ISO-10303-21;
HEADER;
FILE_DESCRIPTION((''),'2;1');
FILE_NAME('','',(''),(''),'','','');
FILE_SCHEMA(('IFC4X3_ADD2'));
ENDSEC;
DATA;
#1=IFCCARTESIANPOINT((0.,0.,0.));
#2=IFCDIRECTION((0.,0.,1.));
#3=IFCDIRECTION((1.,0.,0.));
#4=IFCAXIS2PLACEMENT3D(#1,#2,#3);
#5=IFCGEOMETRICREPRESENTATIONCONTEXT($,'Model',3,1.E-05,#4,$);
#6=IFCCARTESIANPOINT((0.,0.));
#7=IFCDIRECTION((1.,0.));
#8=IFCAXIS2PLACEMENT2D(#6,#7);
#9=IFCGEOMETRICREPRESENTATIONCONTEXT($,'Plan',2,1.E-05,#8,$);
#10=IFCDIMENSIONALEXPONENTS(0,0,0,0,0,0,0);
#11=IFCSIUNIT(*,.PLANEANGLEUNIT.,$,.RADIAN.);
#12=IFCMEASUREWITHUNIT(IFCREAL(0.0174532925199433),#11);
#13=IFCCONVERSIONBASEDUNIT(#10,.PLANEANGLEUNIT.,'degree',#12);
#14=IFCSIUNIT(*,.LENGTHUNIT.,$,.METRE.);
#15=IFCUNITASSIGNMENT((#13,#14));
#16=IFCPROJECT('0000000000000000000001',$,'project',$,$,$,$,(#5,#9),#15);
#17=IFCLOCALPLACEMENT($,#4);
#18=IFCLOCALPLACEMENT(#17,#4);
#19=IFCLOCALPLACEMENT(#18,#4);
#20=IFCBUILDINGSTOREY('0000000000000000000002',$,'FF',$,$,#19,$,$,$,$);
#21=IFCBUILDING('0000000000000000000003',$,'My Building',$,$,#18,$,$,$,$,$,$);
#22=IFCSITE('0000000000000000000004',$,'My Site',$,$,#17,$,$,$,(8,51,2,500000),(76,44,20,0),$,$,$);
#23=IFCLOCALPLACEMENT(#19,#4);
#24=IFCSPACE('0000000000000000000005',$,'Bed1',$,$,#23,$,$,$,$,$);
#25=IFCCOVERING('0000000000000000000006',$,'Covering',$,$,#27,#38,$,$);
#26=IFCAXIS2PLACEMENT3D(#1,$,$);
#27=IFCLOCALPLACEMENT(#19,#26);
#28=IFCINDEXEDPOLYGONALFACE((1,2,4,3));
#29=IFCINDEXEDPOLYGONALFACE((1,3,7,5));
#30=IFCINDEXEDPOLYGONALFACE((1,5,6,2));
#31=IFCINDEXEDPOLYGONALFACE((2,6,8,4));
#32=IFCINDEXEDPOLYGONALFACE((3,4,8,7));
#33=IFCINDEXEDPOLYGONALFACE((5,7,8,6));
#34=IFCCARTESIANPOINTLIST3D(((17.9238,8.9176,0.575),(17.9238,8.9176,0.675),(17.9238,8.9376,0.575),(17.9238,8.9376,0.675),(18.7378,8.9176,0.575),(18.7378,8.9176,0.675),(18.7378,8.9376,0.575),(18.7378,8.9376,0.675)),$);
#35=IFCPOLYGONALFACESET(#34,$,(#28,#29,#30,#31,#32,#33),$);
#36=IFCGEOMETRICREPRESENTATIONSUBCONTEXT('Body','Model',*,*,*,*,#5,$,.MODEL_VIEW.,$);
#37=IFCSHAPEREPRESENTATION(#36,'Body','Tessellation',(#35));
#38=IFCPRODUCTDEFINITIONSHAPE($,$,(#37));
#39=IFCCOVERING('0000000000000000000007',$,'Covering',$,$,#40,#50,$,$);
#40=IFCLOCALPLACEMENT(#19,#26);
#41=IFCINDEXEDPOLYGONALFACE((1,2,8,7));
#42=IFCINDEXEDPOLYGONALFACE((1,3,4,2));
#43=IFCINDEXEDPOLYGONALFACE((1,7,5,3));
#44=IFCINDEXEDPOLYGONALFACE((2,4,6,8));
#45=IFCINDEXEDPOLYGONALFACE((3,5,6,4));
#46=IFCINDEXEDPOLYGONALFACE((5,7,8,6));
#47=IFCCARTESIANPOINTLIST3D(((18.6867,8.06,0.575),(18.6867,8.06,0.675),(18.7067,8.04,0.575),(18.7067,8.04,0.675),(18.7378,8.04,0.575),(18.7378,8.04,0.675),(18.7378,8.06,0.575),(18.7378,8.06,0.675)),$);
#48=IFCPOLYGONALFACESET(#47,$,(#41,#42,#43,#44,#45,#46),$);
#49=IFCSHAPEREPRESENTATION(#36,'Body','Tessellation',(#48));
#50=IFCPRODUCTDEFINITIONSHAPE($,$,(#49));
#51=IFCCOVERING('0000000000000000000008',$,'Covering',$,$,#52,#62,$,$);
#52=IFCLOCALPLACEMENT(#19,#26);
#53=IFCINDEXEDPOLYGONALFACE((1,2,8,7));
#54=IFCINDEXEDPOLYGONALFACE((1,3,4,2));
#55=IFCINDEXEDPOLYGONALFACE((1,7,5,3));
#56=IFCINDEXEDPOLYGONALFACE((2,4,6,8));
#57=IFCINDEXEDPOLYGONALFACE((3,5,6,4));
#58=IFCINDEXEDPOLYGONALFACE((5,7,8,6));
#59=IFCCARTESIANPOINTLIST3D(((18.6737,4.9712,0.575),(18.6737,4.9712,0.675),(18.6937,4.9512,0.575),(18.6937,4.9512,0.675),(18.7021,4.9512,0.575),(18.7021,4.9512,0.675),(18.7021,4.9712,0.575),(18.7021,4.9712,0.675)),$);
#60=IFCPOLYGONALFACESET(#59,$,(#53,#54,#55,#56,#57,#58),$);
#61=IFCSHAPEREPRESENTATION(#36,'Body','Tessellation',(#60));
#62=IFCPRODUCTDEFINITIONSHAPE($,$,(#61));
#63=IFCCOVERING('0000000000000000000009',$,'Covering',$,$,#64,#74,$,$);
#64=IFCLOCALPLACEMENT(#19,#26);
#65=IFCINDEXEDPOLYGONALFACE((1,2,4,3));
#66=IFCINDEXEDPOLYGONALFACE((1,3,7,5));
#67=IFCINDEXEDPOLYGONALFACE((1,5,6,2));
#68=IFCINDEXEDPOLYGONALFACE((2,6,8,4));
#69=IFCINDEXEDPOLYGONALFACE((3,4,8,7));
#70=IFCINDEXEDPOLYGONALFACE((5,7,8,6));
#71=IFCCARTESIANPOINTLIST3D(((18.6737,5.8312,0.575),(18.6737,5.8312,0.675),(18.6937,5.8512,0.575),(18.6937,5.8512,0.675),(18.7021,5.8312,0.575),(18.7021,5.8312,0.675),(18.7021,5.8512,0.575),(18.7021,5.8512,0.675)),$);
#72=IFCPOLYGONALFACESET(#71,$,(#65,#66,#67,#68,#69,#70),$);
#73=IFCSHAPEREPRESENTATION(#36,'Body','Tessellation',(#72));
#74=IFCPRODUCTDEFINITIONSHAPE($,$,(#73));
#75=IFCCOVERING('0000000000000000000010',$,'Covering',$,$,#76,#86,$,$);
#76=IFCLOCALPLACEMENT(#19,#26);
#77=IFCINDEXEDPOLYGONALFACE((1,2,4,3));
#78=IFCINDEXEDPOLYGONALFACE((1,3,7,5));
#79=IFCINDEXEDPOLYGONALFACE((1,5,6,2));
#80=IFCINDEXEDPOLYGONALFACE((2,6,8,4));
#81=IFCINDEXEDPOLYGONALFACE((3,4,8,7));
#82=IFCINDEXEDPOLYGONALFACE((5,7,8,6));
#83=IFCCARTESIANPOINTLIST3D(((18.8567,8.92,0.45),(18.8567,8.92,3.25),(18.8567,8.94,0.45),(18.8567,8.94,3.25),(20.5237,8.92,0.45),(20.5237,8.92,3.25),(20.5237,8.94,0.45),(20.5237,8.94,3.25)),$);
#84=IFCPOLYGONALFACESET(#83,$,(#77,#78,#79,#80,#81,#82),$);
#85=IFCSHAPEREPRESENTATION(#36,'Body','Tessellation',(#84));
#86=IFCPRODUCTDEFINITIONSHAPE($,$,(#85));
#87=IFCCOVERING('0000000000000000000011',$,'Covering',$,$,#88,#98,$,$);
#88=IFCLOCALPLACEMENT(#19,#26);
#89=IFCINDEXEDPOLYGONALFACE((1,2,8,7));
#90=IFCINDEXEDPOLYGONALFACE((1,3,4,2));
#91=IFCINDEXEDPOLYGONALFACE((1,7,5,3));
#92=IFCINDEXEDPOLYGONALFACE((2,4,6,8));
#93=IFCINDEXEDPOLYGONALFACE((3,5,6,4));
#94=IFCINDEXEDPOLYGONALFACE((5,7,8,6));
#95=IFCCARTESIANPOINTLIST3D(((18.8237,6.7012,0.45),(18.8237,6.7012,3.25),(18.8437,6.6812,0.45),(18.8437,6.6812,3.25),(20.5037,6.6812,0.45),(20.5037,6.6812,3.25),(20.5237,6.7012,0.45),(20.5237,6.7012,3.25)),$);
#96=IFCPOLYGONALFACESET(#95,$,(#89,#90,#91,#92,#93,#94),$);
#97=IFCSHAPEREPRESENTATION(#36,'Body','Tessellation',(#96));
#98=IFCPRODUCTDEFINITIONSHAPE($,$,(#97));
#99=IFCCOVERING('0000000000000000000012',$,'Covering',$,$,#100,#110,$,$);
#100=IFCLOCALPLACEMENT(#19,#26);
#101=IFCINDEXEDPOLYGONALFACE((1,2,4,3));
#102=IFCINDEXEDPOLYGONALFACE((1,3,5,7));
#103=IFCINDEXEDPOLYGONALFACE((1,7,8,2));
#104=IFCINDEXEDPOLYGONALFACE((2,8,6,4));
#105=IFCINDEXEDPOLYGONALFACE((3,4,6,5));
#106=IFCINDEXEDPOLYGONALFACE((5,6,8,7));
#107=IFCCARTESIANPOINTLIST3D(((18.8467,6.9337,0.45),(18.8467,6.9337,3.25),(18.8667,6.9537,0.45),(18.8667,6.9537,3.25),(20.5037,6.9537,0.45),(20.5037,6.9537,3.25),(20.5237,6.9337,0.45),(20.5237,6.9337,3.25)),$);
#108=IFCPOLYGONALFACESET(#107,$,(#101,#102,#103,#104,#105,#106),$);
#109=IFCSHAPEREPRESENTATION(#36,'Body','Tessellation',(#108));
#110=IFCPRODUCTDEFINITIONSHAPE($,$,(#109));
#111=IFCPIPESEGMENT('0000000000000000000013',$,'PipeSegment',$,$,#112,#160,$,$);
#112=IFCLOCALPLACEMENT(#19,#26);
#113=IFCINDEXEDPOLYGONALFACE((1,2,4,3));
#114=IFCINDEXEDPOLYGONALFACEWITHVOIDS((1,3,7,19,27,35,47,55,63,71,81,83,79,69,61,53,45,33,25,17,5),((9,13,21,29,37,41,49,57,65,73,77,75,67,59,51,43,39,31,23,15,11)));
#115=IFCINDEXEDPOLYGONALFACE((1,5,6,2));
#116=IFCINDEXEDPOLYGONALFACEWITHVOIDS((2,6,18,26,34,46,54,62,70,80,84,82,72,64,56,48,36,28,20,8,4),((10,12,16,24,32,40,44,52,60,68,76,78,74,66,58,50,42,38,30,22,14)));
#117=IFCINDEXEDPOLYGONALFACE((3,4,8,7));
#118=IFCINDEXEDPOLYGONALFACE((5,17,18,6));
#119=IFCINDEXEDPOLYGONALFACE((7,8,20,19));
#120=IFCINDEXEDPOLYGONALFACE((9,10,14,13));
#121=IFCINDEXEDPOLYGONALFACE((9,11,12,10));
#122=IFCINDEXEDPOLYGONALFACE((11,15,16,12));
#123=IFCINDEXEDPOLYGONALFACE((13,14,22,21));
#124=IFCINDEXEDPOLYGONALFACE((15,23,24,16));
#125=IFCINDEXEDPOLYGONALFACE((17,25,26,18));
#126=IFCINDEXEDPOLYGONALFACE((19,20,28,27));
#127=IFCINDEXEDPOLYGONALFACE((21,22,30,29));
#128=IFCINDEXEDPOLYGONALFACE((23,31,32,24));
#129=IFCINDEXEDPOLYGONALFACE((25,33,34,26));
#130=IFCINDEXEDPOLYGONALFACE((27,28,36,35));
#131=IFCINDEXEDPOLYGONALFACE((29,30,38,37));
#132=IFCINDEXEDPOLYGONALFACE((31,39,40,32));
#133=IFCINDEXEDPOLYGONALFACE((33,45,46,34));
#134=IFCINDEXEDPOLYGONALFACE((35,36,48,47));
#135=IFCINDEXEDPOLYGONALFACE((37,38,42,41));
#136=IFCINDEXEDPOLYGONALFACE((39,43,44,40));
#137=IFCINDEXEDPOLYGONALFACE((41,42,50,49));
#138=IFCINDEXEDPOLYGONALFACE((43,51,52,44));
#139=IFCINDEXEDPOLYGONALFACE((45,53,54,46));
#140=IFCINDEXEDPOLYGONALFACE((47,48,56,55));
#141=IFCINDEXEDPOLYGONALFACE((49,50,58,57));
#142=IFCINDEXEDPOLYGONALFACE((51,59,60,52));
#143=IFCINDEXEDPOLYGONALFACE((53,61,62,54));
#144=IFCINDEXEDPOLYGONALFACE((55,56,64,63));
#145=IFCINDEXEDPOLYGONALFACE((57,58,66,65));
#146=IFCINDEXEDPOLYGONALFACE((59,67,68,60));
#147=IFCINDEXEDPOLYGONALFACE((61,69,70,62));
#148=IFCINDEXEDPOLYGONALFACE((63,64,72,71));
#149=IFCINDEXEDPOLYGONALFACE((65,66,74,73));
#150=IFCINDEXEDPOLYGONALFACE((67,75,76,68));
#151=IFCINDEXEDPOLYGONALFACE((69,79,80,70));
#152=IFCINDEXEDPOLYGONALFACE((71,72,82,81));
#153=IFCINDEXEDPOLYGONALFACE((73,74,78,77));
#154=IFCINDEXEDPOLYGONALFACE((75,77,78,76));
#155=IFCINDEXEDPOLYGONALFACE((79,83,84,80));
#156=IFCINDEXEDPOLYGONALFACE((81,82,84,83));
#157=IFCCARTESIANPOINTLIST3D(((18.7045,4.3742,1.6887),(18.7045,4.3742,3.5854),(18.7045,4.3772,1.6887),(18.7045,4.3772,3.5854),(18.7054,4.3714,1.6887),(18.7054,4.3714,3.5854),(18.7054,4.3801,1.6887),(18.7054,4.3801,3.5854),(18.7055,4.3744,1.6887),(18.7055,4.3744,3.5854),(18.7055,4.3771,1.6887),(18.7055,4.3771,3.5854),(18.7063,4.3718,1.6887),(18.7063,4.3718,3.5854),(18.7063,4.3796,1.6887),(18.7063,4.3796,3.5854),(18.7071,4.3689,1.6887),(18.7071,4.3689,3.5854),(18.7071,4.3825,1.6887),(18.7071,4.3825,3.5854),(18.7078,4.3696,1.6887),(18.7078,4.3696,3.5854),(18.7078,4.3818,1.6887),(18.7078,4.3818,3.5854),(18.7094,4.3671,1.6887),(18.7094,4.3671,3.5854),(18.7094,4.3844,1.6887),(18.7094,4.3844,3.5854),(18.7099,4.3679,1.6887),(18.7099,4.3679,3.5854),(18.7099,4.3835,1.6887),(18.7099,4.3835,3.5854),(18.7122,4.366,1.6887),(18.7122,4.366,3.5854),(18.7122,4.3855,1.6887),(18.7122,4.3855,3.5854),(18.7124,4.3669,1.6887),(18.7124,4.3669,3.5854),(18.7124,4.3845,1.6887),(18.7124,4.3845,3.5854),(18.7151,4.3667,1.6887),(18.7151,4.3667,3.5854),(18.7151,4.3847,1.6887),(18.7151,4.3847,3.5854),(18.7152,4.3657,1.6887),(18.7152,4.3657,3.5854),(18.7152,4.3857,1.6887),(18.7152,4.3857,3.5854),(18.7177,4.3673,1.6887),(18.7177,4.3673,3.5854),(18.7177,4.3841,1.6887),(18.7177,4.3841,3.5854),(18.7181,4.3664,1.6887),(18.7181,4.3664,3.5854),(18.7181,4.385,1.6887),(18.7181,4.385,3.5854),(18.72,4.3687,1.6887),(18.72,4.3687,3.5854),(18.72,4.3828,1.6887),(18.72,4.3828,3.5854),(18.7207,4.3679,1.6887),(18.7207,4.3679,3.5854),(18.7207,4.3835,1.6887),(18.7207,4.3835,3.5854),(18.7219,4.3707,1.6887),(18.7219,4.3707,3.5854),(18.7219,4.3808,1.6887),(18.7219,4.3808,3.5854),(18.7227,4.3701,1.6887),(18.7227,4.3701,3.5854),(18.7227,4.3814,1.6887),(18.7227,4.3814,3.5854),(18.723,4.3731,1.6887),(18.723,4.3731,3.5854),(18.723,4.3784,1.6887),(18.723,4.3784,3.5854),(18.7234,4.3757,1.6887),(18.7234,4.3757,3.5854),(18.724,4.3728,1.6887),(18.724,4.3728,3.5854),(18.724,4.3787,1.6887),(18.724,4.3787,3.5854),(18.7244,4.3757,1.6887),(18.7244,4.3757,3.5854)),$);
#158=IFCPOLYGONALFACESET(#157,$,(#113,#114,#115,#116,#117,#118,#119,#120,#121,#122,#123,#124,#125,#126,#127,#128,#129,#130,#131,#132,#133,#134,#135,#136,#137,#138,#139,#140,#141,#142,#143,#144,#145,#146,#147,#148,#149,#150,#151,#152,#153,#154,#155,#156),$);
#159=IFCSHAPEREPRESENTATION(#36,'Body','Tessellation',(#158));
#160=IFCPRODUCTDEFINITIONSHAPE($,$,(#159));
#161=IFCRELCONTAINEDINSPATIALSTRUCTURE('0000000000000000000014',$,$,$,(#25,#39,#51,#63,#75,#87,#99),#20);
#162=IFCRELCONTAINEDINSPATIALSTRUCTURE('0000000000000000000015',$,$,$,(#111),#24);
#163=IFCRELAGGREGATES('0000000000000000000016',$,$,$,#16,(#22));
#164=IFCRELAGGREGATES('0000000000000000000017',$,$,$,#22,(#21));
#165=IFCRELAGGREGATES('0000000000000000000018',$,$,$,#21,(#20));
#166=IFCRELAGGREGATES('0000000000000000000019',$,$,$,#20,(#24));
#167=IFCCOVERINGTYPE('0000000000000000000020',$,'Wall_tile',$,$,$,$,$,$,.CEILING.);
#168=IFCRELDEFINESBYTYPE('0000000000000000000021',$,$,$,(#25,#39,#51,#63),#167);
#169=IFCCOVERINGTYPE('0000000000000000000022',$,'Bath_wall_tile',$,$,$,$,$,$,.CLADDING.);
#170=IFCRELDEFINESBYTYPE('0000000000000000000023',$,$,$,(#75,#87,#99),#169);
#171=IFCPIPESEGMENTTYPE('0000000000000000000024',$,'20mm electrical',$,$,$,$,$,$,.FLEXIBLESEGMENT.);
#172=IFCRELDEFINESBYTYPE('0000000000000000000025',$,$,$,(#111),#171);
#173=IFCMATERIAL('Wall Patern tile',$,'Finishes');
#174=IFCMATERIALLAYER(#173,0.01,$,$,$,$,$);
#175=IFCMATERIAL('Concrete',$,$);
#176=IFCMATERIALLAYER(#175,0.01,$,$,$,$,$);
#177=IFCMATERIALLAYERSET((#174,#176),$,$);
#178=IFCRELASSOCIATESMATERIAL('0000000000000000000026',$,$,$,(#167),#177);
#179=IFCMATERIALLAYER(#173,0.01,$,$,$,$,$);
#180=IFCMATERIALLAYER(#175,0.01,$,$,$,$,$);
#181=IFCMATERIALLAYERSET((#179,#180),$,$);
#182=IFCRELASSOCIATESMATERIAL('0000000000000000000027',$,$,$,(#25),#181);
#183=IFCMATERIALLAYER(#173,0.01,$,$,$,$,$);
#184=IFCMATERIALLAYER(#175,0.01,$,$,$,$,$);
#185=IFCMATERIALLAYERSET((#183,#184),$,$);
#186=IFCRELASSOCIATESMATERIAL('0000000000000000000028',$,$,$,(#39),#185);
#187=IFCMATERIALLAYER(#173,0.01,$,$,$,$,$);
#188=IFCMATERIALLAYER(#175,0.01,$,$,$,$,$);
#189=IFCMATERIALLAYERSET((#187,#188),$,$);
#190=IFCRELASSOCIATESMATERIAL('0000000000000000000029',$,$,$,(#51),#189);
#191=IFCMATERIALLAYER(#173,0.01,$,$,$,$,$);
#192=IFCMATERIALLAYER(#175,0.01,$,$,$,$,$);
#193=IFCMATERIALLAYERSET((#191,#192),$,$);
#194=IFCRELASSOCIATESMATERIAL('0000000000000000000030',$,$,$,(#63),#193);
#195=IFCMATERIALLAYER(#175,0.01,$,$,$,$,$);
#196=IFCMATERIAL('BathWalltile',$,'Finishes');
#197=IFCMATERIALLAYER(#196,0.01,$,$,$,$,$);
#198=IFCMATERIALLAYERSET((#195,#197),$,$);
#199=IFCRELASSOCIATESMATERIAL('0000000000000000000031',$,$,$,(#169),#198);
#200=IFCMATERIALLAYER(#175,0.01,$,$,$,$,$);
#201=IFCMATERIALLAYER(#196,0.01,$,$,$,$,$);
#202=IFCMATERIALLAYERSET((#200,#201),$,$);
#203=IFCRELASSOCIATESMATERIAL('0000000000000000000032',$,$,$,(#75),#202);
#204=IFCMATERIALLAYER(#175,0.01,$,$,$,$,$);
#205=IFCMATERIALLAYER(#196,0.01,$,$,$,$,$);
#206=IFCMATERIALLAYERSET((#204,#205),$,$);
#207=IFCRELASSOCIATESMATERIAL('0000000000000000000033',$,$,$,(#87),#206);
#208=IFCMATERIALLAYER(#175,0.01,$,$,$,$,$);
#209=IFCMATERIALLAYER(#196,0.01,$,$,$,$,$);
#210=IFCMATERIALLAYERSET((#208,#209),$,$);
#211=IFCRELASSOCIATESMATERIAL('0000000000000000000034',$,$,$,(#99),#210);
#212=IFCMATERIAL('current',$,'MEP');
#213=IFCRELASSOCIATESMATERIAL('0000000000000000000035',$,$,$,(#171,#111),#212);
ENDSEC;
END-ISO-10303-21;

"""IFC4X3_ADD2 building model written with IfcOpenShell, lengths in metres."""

from ifc_helpers import new_model, entity, si_unit, converted_unit, frame, origin_with_axes, origin_2d_with_axis, place, context, subcontext, project, spatial, line, indexed_curve, hollow_circle, outline, extrude, material, layer, layer_set, layer_usage, material_profile, profile_set, profile_usage, type_object, element, save


model = new_model("IFC4X3_ADD2")

# Units and contexts
model_context = context("Model", 3, precision=1e-05, world=origin_with_axes())
plan_context = context("Plan", 2, precision=1e-05, world=origin_2d_with_axis())
body_context_1 = subcontext(model_context, "Body", "Model", "MODEL_VIEW")
ifc_project = project(units=[converted_unit("PLANEANGLEUNIT", "degree", entity("IfcReal", 0.0174532925199433), si_unit("PLANEANGLEUNIT", "RADIAN"), dimensions=[0, 0, 0, 0, 0, 0, 0]), si_unit("LENGTHUNIT", "METRE")], contexts=[model_context, plan_context])

# Site, building, storey
site_placement = place(None, origin_with_axes())
site = spatial("IfcSite", under=ifc_project, at=site_placement, Name="My Site", RefLatitude=(8, 51, 2, 500000), RefLongitude=(76, 44, 20, 0))
building_placement = place(site_placement, origin_with_axes())
building = spatial("IfcBuilding", under=site, at=building_placement, Name="My Building")
storey_placement = place(building_placement, origin_with_axes())
storey = spatial("IfcBuildingStorey", under=building, at=storey_placement, Name="FF")

# Coverings
ifc_material_1 = material(Name="Wall Patern tile", Category="Finishes")
ifc_material_2 = material(Name="Concrete")
ifc_layer_1 = layer(ifc_material_1, 0.01)
ifc_layer_2 = layer(ifc_material_2, 0.01)
ifc_layer_set_1 = layer_set([ifc_layer_1, ifc_layer_2])
covering_type_1 = type_object("IfcCoveringType", Name="Wall_tile", PredefinedType="CEILING", material=ifc_layer_set_1)
ifc_layer_3 = layer(ifc_material_1, 0.01)
ifc_layer_4 = layer(ifc_material_2, 0.01)
ifc_layer_set_2 = layer_set([ifc_layer_3, ifc_layer_4])
ifc_layer_usage_1 = layer_usage(ifc_layer_set_2, "AXIS2", "NEGATIVE", 0.0)
covering_1_placement = place(storey_placement, frame((18.7378, 8.9176, 0.575), z_axis=(0.0, 0.0, 1.0), x_axis=(-1.0, 0.0, 0.0)))
element("IfcCovering", 1, at=covering_1_placement, inside=storey, type_object=covering_type_1, material=ifc_layer_usage_1, Name="Covering", context=body_context_1, shape_type="SweptSolid", body=[
    extrude(outline(indexed_curve([(0.0, -0.02), (0.0, 0.0), (0.814, 0.0), (0.814, -0.02)], segments=[line(1, 2, 3, 4, 1)])), origin_with_axes(), (0.0, 0.0, 1.0), 0.1),
])
ifc_layer_5 = layer(ifc_material_1, 0.01)
ifc_layer_6 = layer(ifc_material_2, 0.01)
ifc_layer_set_3 = layer_set([ifc_layer_5, ifc_layer_6])
ifc_layer_usage_2 = layer_usage(ifc_layer_set_3, "AXIS2", "POSITIVE", 0.0)
covering_2_placement = place(storey_placement, frame((18.7378, 8.06, 0.575), z_axis=(0.0, 0.0, 1.0), x_axis=(-1.0, 0.0, 0.0)))
element("IfcCovering", 2, at=covering_2_placement, inside=storey, type_object=covering_type_1, material=ifc_layer_usage_2, Name="Covering", context=body_context_1, shape_type="SweptSolid", body=[
    extrude(outline(indexed_curve([(0.0, 0.0), (0.0, 0.02), (0.0311, 0.02), (0.0511, 0.0)], segments=[line(1, 2, 3, 4, 1)])), origin_with_axes(), (0.0, 0.0, 1.0), 0.1),
])
ifc_layer_7 = layer(ifc_material_1, 0.01)
ifc_layer_8 = layer(ifc_material_2, 0.01)
ifc_layer_set_4 = layer_set([ifc_layer_7, ifc_layer_8])
ifc_layer_usage_3 = layer_usage(ifc_layer_set_4, "AXIS2", "NEGATIVE", 0.0)
covering_3_placement = place(storey_placement, frame((18.6737, 4.9712, 0.575), z_axis=(0.0, 0.0, 1.0), x_axis=(1.0, 0.0, 0.0)))
element("IfcCovering", 3, at=covering_3_placement, inside=storey, type_object=covering_type_1, material=ifc_layer_usage_3, Name="Covering", context=body_context_1, shape_type="SweptSolid", body=[
    extrude(outline(indexed_curve([(0.02, -0.02), (0.0, 0.0), (0.0284, 0.0), (0.0284, -0.02)], segments=[line(1, 2, 3, 4, 1)])), origin_with_axes(), (0.0, 0.0, 1.0), 0.1),
])
ifc_layer_9 = layer(ifc_material_1, 0.01)
ifc_layer_10 = layer(ifc_material_2, 0.01)
ifc_layer_set_5 = layer_set([ifc_layer_9, ifc_layer_10])
ifc_layer_usage_4 = layer_usage(ifc_layer_set_5, "AXIS2", "POSITIVE", 0.0)
covering_4_placement = place(storey_placement, frame((18.6737, 5.8312, 0.575), z_axis=(0.0, 0.0, 1.0), x_axis=(1.0, 0.0, 0.0)))
element("IfcCovering", 4, at=covering_4_placement, inside=storey, type_object=covering_type_1, material=ifc_layer_usage_4, Name="Covering", context=body_context_1, shape_type="SweptSolid", body=[
    extrude(outline(indexed_curve([(0.0, 0.0), (0.02, 0.02), (0.0284, 0.02), (0.0284, 0.0)], segments=[line(1, 2, 3, 4, 1)])), origin_with_axes(), (0.0, 0.0, 1.0), 0.1),
])
ifc_layer_11 = layer(ifc_material_2, 0.01)
ifc_material_3 = material(Name="BathWalltile", Category="Finishes")
ifc_layer_12 = layer(ifc_material_3, 0.01)
ifc_layer_set_6 = layer_set([ifc_layer_11, ifc_layer_12])
ifc_layer_usage_5 = layer_usage(ifc_layer_set_6, "AXIS2", "NEGATIVE", 0.0)
ifc_layer_13 = layer(ifc_material_2, 0.01)
ifc_layer_14 = layer(ifc_material_3, 0.01)
ifc_layer_set_7 = layer_set([ifc_layer_13, ifc_layer_14])
covering_type_2 = type_object("IfcCoveringType", Name="Bath_wall_tile", PredefinedType="CLADDING", material=ifc_layer_set_7)
covering_5_placement = place(storey_placement, frame((18.8567, 8.94, 0.45), z_axis=(0.0, 0.0, 1.0), x_axis=(1.0, 0.0, 0.0)))
element("IfcCovering", 5, at=covering_5_placement, inside=storey, type_object=covering_type_2, material=ifc_layer_usage_5, Name="Covering", context=body_context_1, shape_type="SweptSolid", body=[
    extrude(outline(indexed_curve([(0.0, -0.02), (0.0, 0.0), (1.667, 0.0), (1.667, -0.02)], segments=[line(1, 2, 3, 4, 1)])), origin_with_axes(), (0.0, 0.0, 1.0), 2.8),
])
ifc_layer_15 = layer(ifc_material_2, 0.01)
ifc_layer_16 = layer(ifc_material_3, 0.01)
ifc_layer_set_8 = layer_set([ifc_layer_15, ifc_layer_16])
ifc_layer_usage_6 = layer_usage(ifc_layer_set_8, "AXIS2", "NEGATIVE", 0.0)
covering_6_placement = place(storey_placement, frame((18.8237, 6.7012, 0.45), z_axis=(0.0, 0.0, 1.0), x_axis=(1.0, 0.0, 0.0)))
element("IfcCovering", 6, at=covering_6_placement, inside=storey, type_object=covering_type_2, material=ifc_layer_usage_6, Name="Covering", context=body_context_1, shape_type="SweptSolid", body=[
    extrude(outline(indexed_curve([(0.02, -0.02), (0.0, 0.0), (1.7, 0.0), (1.68, -0.02)], segments=[line(1, 2, 3, 4, 1)])), origin_with_axes(), (0.0, 0.0, 1.0), 2.8),
])
ifc_layer_17 = layer(ifc_material_2, 0.01)
ifc_layer_18 = layer(ifc_material_3, 0.01)
ifc_layer_set_9 = layer_set([ifc_layer_17, ifc_layer_18])
ifc_layer_usage_7 = layer_usage(ifc_layer_set_9, "AXIS2", "POSITIVE", 0.0)
covering_7_placement = place(storey_placement, frame((18.8467, 6.9337, 0.45), z_axis=(0.0, 0.0, 1.0), x_axis=(1.0, 0.0, 0.0)))
element("IfcCovering", 7, at=covering_7_placement, inside=storey, type_object=covering_type_2, material=ifc_layer_usage_7, Name="Covering", context=body_context_1, shape_type="SweptSolid", body=[
    extrude(outline(indexed_curve([(0.0, 0.0), (0.02, 0.02), (1.657, 0.02), (1.677, 0.0)], segments=[line(1, 2, 3, 4, 1)])), origin_with_axes(), (0.0, 0.0, 1.0), 2.8),
])

# Shared definitions
space_1_placement = place(storey_placement, origin_with_axes())
space_1 = spatial("IfcSpace", under=storey, at=space_1_placement, Name="Bed1")

# Pipe segment
ifc_material_4 = material(Name="current", Category="MEP")
ifc_material_profile_1 = material_profile(ifc_material_4, hollow_circle(Radius=0.01, WallThickness=0.001))
ifc_profile_set_1 = profile_set([ifc_material_profile_1], Name="current")
ifc_profile_usage_1 = profile_usage(ifc_profile_set_1, cardinal=5)
pipe_segment_type = type_object("IfcPipeSegmentType", Name="20mm electrical", PredefinedType="FLEXIBLESEGMENT", material=ifc_profile_set_1)
pipe_segment_1_placement = place(space_1_placement, frame((18.7144, 4.3757, 1.6887), z_axis=(0.0, 0.0, 1.0), x_axis=(1.0, 0.0, 0.0)))
element("IfcPipeSegment", 8, at=pipe_segment_1_placement, inside=space_1, type_object=pipe_segment_type, material=ifc_profile_usage_1, Name="PipeSegment", context=body_context_1, shape_type="SweptSolid", body=[
    extrude(hollow_circle(Radius=0.01, WallThickness=0.001), origin_with_axes(), (0.0, 0.0, 1.0), 1.8967),
])

save(model, "model.ifc")
